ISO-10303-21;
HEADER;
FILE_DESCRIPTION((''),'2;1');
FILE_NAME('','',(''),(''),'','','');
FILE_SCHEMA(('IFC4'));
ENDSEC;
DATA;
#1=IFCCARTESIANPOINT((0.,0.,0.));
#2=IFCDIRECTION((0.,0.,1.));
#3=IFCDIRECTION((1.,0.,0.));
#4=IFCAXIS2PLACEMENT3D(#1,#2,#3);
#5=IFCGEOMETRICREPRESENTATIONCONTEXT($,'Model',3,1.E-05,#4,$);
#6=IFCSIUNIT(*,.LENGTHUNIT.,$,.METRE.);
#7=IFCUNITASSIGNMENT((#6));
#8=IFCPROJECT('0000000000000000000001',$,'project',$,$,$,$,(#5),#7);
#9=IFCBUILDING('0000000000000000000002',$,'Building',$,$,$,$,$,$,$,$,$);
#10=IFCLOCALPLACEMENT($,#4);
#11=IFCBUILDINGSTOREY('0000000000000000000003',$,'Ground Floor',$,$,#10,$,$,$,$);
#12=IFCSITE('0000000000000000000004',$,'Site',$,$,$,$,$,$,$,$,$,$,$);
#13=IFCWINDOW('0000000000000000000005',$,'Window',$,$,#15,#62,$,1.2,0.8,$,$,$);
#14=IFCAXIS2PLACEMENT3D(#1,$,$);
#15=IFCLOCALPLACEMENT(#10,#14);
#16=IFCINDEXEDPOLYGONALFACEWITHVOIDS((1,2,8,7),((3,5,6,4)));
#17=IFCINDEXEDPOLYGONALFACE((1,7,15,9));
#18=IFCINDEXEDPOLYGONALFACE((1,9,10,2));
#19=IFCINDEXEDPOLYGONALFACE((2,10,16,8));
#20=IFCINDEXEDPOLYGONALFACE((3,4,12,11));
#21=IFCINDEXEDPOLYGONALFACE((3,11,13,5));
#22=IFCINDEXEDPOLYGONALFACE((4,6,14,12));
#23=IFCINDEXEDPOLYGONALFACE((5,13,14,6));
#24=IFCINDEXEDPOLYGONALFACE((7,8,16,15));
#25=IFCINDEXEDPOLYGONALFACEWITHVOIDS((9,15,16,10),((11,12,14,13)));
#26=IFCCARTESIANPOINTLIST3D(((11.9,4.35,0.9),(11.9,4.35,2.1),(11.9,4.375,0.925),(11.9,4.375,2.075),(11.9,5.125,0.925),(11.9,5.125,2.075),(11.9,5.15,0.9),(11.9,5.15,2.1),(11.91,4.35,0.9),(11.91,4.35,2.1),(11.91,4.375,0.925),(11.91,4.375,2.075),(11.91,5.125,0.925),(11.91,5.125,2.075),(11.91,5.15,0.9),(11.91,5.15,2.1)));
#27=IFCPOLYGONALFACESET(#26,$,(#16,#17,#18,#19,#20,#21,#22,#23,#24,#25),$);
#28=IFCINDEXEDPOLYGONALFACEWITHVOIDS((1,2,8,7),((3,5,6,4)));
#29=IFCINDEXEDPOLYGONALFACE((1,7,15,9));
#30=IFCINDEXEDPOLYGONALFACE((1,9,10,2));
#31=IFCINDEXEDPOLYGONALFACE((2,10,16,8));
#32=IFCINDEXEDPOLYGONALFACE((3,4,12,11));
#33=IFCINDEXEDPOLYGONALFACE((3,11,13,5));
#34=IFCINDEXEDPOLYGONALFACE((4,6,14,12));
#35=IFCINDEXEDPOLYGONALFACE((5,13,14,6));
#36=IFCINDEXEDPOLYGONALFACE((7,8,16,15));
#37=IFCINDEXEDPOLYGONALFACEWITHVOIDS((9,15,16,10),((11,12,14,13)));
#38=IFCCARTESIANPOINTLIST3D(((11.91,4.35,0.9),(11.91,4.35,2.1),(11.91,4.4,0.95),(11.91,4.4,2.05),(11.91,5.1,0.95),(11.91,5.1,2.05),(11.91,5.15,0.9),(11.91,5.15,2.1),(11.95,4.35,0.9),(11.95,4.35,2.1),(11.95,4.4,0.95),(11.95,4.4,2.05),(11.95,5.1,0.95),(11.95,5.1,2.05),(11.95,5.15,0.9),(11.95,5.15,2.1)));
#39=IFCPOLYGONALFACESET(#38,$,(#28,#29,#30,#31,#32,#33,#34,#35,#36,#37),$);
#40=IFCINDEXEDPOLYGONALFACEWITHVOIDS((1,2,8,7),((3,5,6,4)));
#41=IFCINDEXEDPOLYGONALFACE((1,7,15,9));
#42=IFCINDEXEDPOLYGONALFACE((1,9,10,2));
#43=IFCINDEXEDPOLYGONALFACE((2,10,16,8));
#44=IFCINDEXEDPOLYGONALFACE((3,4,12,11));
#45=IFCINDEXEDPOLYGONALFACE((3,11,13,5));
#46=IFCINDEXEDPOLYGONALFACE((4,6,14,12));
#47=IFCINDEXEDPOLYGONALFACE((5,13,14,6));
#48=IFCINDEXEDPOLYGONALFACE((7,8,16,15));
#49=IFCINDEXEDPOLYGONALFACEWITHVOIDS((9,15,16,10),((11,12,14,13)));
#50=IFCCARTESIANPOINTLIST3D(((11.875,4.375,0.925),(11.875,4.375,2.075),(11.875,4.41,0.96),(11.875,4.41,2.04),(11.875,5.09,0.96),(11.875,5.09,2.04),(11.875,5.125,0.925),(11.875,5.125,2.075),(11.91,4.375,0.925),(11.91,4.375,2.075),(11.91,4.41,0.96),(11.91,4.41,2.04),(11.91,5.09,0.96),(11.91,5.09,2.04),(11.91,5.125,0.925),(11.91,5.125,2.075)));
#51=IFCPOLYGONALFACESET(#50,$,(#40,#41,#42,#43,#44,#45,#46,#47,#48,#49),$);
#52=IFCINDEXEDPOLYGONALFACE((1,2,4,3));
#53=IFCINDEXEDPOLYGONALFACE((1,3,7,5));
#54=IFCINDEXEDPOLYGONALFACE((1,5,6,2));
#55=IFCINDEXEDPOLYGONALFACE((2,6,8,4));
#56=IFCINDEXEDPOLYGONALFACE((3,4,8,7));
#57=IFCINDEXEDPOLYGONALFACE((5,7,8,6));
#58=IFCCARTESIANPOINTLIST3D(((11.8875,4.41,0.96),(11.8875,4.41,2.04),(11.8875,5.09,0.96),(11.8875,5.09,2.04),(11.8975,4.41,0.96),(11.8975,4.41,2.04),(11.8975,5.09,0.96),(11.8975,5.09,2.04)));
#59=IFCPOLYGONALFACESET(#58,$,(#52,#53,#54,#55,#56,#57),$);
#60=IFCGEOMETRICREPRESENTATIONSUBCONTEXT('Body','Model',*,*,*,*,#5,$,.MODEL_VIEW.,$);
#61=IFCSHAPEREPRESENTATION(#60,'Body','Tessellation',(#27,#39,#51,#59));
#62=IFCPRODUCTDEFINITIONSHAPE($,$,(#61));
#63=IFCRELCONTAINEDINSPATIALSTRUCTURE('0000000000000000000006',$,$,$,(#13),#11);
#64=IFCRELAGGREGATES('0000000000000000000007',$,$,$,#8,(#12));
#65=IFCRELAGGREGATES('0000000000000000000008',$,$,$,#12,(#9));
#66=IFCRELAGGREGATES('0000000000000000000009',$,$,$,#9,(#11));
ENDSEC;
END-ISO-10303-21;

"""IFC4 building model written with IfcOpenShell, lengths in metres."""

from ifc_helpers import new_model, si_unit, frame, origin_with_axes, place, context, subcontext, project, spatial, line, indexed_curve, outline, extrude, element, save


model = new_model("IFC4")

# Units and contexts
model_context = context("Model", 3, precision=1e-05, world=origin_with_axes())
body_context = subcontext(model_context, "Body", "Model", "MODEL_VIEW")
ifc_project = project(units=[si_unit("LENGTHUNIT", "METRE")], contexts=[model_context])

# Site, building, storey
site = spatial("IfcSite", under=ifc_project, Name="Site")
building = spatial("IfcBuilding", under=site, Name="Building")
storey_placement = place(None, origin_with_axes())
storey = spatial("IfcBuildingStorey", under=building, at=storey_placement, Name="Ground Floor")

# Window
window_1_placement = place(storey_placement, frame((12.0, 4.35, 0.9), z_axis=(0.0, 0.0, 1.0), x_axis=(0.0, 1.0, 0.0)))
element("IfcWindow", 1, at=window_1_placement, inside=storey, Name="Window", OverallHeight=1.2, OverallWidth=0.8, context=body_context, shape_type="SweptSolid", body=[
    extrude(outline(indexed_curve([(0.0, 0.0), (0.8, 0.0), (0.8, 1.2), (0.0, 1.2)], segments=[line(1, 2, 3, 4, 1)]), holes=[indexed_curve([(0.025, 0.025), (0.775, 0.025), (0.775, 1.175), (0.025, 1.175)], segments=[line(1, 2, 3, 4, 1)])]), frame((0.0, 0.09, 0.0), z_axis=(0.0, -1.0, 0.0), x_axis=(1.0, 0.0, 0.0)), (0.0, 0.0, -1.0), 0.01),
    extrude(outline(indexed_curve([(0.0, 0.0), (0.8, 0.0), (0.8, 1.2), (0.0, 1.2)], segments=[line(1, 2, 3, 4, 1)]), holes=[indexed_curve([(0.05, 0.05), (0.75, 0.05), (0.75, 1.15), (0.05, 1.15)], segments=[line(1, 2, 3, 4, 1)])]), frame((0.0, 0.05, 0.0), z_axis=(0.0, -1.0, 0.0), x_axis=(1.0, 0.0, 0.0)), (0.0, 0.0, -1.0), 0.04),
    extrude(outline(indexed_curve([(0.0, 0.0), (0.75, 0.0), (0.75, 1.15), (0.0, 1.15)], segments=[line(1, 2, 3, 4, 1)]), holes=[indexed_curve([(0.035, 0.035), (0.715, 0.035), (0.715, 1.115), (0.035, 1.115)], segments=[line(1, 2, 3, 4, 1)])]), frame((0.025, 0.09, 0.025), z_axis=(0.0, -1.0, 0.0), x_axis=(1.0, 0.0, 0.0)), (0.0, 0.0, -1.0), 0.035),
    extrude(outline(indexed_curve([(0.035, 0.035), (0.715, 0.035), (0.715, 1.115), (0.035, 1.115)], segments=[line(1, 2, 3, 4, 1)])), frame((0.025, 0.1025, 0.025), z_axis=(0.0, -1.0, 0.0), x_axis=(1.0, 0.0, 0.0)), (0.0, 0.0, -1.0), 0.01),
])

save(model, "model.ifc")
